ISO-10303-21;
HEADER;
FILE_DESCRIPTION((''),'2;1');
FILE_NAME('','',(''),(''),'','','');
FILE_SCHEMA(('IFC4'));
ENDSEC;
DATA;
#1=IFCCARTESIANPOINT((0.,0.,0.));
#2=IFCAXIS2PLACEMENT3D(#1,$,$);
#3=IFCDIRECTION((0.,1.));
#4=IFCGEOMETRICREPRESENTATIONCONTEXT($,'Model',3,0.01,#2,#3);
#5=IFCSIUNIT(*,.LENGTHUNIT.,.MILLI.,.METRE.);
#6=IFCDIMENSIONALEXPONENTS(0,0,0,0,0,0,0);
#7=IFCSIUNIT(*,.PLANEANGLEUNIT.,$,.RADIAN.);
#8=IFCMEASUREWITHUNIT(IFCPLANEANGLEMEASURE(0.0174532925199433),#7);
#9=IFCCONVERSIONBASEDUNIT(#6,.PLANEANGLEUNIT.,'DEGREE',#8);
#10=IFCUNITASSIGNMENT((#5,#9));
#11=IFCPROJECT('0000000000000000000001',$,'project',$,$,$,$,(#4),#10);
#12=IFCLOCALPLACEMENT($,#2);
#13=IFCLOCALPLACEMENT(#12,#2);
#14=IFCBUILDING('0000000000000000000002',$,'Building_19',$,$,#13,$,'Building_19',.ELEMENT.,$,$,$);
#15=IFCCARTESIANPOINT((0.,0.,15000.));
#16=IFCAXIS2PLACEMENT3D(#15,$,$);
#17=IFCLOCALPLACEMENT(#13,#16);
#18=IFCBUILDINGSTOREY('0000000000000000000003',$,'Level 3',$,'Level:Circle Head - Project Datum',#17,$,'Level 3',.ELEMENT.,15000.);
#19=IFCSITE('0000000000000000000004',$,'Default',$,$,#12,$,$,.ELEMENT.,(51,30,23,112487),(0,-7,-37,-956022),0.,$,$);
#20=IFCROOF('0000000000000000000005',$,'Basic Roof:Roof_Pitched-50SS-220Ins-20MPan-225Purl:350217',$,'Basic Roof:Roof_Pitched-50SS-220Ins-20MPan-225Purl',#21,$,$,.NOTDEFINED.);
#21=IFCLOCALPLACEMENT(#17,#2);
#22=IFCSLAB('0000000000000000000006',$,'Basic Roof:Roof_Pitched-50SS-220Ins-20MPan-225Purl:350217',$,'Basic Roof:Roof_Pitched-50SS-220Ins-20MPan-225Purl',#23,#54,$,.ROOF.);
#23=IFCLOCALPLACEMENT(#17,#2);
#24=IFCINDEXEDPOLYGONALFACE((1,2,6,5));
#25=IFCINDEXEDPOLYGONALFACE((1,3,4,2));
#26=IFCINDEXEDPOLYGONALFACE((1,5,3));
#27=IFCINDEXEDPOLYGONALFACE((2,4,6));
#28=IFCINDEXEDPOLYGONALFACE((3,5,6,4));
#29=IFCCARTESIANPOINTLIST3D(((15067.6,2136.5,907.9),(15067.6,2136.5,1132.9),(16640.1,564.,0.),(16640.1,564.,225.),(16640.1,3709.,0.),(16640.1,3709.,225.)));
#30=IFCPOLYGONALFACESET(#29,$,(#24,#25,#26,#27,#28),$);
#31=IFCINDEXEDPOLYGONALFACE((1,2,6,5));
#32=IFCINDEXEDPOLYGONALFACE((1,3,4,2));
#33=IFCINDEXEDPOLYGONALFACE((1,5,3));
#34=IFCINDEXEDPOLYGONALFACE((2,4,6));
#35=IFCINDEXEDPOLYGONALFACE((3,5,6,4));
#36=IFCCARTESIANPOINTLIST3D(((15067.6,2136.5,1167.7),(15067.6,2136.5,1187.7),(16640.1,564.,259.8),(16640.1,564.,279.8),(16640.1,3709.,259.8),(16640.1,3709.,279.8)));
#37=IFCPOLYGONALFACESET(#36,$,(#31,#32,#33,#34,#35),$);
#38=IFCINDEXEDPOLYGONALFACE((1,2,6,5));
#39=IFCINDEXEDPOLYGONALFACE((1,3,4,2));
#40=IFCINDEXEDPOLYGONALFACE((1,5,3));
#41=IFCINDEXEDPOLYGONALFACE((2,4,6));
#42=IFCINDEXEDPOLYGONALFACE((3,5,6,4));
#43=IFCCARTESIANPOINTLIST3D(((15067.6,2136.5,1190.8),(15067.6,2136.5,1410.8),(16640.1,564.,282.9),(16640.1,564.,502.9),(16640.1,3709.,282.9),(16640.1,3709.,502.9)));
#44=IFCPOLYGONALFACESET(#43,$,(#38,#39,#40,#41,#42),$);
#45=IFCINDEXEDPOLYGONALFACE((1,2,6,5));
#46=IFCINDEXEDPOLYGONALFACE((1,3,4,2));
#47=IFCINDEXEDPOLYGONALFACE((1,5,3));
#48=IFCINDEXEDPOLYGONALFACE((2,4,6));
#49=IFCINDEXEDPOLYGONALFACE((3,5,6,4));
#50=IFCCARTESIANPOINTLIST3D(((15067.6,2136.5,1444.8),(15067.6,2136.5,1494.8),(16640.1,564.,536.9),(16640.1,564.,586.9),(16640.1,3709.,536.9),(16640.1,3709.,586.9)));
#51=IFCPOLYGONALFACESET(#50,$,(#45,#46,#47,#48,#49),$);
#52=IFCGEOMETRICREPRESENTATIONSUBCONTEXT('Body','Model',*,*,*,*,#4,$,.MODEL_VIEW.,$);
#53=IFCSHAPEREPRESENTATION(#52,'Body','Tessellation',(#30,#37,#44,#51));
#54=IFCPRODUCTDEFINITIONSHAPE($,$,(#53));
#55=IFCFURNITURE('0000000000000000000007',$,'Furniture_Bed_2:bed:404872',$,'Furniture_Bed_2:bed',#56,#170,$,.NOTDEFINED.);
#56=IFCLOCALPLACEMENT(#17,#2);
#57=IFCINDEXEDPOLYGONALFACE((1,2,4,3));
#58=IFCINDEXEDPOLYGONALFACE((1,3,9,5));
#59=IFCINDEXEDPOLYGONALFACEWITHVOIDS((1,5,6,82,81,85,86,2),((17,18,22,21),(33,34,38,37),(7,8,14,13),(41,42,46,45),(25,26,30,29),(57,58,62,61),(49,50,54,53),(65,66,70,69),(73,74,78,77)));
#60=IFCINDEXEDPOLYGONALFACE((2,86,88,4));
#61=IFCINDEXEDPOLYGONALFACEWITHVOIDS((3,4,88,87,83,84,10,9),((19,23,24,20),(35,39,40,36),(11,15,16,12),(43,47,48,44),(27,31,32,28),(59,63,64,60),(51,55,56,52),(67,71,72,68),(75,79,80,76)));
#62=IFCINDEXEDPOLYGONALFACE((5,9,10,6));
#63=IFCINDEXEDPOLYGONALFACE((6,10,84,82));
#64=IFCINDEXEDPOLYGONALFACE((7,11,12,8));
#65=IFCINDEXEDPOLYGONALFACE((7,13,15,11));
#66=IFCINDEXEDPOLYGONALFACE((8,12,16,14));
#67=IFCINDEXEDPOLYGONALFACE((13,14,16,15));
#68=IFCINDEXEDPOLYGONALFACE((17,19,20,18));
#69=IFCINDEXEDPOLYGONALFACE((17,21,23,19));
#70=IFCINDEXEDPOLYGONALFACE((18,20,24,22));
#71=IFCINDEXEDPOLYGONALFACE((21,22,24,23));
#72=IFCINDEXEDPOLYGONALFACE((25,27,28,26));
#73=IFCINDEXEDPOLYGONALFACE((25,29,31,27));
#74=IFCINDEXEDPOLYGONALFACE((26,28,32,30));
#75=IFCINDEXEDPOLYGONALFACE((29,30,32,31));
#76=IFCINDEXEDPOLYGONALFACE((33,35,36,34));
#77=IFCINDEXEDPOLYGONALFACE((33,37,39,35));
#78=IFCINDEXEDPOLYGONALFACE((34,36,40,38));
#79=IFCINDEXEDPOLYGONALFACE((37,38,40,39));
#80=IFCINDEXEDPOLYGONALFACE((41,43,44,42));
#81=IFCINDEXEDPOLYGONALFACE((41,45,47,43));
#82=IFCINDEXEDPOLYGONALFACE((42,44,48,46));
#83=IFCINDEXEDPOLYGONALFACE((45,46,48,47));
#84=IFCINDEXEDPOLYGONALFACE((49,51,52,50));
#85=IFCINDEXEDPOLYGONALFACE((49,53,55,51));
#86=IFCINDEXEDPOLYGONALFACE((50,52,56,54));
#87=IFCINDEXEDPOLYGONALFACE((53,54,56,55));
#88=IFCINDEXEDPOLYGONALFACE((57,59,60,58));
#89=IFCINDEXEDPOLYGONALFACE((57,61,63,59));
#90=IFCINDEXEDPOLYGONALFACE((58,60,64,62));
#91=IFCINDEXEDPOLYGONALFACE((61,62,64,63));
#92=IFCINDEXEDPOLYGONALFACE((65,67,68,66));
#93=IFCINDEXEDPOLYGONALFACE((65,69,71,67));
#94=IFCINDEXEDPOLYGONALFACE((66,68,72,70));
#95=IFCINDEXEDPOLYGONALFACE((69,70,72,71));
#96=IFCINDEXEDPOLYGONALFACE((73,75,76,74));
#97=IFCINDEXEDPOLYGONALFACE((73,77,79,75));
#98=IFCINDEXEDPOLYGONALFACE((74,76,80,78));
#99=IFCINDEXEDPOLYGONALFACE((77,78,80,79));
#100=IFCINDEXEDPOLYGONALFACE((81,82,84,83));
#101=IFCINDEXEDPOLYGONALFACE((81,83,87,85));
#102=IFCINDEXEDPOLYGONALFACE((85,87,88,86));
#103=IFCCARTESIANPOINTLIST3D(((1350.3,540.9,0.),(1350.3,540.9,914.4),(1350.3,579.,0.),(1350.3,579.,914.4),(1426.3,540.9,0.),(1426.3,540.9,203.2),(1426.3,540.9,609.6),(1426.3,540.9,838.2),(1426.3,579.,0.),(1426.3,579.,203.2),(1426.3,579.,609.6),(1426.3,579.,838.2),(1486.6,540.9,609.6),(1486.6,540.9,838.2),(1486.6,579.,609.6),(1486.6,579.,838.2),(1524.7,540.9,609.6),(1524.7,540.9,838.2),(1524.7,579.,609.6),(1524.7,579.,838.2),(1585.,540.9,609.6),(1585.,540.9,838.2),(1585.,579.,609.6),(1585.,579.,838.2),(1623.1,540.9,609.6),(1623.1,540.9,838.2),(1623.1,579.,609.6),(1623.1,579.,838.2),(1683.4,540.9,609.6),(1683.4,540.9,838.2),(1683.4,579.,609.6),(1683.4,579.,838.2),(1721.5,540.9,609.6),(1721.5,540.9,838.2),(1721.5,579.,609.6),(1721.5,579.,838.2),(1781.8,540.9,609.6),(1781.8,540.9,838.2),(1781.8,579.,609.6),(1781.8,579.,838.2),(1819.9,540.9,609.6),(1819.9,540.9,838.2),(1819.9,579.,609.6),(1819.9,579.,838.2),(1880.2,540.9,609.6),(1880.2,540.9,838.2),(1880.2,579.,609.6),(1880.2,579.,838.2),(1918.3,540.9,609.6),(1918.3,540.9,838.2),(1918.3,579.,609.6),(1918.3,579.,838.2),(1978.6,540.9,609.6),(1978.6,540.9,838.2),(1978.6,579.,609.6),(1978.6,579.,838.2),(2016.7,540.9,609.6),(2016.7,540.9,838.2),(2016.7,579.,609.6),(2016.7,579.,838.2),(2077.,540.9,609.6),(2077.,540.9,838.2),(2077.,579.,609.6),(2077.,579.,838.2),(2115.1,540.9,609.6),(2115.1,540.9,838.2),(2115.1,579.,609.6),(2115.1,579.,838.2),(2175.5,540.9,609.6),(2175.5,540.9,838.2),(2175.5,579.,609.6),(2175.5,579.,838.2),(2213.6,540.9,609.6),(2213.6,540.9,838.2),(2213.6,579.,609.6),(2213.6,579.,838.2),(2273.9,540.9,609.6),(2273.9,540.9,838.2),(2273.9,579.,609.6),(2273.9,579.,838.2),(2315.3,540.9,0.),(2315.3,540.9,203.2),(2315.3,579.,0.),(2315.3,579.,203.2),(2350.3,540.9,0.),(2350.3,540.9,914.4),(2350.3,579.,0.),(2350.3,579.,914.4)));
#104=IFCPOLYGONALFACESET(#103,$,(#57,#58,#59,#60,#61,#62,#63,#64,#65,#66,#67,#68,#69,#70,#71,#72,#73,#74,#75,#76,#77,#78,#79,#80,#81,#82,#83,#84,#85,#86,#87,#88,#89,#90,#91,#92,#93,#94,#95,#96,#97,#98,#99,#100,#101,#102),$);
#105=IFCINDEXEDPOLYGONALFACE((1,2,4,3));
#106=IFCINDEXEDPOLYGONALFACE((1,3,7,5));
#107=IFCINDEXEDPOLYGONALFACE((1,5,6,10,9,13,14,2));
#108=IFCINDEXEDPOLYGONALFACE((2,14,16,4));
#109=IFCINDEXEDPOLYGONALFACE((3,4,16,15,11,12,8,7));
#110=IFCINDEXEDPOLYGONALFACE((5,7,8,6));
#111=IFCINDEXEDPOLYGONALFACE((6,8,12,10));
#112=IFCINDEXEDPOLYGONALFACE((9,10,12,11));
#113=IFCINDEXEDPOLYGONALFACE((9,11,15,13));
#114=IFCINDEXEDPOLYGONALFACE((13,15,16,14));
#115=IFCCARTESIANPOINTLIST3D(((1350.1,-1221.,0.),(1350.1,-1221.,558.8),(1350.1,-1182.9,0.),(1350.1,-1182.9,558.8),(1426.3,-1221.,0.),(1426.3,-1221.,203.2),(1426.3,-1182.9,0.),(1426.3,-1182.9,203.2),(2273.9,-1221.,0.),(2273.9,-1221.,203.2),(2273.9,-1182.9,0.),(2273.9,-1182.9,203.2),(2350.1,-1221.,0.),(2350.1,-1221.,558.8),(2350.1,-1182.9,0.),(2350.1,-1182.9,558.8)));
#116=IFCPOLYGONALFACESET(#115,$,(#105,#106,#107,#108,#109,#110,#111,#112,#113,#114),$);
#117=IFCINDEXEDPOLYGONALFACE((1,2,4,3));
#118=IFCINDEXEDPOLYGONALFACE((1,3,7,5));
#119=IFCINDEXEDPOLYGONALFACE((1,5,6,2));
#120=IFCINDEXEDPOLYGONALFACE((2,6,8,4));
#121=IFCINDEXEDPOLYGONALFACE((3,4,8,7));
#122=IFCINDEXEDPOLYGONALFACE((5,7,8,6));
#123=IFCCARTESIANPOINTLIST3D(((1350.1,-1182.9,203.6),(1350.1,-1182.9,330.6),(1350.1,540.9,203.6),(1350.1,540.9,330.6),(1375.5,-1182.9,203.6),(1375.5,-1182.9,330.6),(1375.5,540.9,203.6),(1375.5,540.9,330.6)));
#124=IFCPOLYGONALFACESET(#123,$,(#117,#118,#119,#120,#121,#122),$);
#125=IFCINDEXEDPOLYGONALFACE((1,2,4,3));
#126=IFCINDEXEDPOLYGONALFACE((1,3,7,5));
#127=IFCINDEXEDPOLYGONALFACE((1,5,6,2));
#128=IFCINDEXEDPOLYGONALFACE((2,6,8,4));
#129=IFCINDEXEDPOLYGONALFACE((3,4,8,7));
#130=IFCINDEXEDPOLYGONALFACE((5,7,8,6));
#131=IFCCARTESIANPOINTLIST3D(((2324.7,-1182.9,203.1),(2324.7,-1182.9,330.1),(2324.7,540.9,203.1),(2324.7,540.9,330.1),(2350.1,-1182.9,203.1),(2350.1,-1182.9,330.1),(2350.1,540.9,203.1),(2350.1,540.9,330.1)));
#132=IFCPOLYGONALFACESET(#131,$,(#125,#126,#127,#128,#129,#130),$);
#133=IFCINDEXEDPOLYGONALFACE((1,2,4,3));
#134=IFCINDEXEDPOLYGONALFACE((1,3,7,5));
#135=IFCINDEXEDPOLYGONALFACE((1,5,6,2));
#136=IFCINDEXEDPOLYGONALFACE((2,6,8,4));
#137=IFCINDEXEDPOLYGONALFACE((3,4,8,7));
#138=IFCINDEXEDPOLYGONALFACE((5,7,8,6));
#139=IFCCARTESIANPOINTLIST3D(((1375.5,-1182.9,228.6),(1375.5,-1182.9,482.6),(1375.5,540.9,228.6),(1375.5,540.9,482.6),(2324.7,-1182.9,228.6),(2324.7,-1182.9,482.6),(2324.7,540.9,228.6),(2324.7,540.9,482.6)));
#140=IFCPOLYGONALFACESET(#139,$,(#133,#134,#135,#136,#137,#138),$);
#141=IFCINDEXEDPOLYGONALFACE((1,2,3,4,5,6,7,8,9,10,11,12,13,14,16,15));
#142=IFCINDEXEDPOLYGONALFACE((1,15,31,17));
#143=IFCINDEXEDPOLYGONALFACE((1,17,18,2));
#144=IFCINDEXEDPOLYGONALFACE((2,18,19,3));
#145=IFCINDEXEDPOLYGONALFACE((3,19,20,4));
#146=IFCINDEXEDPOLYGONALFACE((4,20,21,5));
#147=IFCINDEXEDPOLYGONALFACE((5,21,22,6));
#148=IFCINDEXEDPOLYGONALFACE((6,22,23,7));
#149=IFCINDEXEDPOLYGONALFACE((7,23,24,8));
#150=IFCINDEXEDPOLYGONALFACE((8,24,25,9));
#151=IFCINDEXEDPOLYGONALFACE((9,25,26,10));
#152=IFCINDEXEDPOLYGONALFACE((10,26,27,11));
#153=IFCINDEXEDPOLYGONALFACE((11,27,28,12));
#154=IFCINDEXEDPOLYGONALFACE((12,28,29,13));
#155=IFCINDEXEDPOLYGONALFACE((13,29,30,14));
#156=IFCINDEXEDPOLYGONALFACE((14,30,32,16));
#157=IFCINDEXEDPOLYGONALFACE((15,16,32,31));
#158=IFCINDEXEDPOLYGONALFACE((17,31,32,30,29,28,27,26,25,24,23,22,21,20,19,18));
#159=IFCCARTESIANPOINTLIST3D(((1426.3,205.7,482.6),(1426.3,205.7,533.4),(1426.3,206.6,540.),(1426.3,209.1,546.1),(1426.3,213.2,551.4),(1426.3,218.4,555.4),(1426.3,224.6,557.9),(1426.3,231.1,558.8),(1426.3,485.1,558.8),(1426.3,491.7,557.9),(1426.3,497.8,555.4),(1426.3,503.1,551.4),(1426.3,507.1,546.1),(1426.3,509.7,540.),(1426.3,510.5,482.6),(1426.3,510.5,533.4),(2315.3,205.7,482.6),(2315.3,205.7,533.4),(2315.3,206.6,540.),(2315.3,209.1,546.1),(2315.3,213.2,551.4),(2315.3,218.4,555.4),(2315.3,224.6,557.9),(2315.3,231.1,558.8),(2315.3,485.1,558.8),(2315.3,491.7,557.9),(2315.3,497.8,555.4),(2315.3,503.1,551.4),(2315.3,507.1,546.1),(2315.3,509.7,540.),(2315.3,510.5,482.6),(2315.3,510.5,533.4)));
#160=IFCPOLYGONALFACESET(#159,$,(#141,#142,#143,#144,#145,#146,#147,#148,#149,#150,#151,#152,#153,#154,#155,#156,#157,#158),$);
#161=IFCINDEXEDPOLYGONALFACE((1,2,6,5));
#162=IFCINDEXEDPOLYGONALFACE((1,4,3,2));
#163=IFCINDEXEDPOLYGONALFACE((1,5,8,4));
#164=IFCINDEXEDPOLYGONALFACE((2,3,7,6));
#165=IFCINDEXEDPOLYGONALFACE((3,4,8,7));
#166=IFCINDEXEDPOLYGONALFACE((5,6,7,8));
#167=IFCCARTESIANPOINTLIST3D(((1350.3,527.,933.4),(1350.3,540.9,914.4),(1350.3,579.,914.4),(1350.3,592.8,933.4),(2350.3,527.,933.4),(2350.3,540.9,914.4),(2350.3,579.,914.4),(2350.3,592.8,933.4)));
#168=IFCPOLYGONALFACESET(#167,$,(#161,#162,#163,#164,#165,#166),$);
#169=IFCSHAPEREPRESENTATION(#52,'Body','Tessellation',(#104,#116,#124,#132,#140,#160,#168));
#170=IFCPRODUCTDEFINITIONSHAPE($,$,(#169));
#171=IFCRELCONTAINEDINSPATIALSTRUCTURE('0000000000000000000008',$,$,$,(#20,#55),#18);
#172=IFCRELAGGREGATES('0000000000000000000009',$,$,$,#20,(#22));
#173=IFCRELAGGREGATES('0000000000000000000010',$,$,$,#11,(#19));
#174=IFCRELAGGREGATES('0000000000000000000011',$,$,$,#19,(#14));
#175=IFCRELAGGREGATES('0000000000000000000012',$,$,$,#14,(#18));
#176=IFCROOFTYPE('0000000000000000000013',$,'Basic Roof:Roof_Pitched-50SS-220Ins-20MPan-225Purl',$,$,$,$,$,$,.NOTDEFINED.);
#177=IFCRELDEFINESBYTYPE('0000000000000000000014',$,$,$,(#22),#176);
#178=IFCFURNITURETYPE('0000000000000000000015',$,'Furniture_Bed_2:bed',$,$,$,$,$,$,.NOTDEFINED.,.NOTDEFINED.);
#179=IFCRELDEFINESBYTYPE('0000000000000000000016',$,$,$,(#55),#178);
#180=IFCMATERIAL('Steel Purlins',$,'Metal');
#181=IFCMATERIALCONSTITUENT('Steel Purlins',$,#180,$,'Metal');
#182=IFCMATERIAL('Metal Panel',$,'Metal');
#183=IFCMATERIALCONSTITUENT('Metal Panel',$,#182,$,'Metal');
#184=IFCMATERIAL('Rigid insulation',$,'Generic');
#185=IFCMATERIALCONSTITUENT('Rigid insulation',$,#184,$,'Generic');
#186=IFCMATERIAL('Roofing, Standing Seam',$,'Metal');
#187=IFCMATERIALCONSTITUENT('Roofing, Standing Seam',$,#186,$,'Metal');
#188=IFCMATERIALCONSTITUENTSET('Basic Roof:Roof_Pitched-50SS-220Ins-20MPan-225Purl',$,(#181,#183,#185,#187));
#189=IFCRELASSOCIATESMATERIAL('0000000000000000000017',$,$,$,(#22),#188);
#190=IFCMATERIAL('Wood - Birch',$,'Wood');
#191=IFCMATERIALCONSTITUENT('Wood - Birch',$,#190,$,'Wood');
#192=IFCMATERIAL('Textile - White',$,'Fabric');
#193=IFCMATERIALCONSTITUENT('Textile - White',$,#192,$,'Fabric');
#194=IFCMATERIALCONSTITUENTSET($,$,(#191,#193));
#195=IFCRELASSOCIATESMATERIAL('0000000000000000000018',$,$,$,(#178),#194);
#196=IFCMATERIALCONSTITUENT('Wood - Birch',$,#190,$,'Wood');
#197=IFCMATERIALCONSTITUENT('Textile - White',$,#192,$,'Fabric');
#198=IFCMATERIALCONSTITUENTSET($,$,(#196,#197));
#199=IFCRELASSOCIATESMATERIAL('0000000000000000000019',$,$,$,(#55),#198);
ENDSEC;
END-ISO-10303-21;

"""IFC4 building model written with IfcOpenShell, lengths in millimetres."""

from ifc_helpers import new_model, entity, si_unit, converted_unit, direction, frame, origin, place, context, subcontext, project, spatial, line, arc, indexed_curve, outline, extrude, source, transform, mapped, material, constituent, constituent_set, type_object, type_shapes, element, aggregate, save


model = new_model("IFC4")

# Units and contexts
model_context = context("Model", 3, precision=0.01, world=origin(), true_north=direction((0.0, 1.0)))
body_context = subcontext(model_context, "Body", "Model", "MODEL_VIEW")
ifc_project = project(units=[si_unit("LENGTHUNIT", "METRE", prefix="MILLI"), converted_unit("PLANEANGLEUNIT", "DEGREE", entity("IfcPlaneAngleMeasure", 0.0174532925199433), si_unit("PLANEANGLEUNIT", "RADIAN"), dimensions=[0, 0, 0, 0, 0, 0, 0])], contexts=[model_context])

# Site, building, storey
site_placement = place(None, origin())
site = spatial("IfcSite", under=ifc_project, at=site_placement, Name="Default", CompositionType="ELEMENT", RefLatitude=(51, 30, 23, 112487), RefLongitude=(0, -7, -37, -956022), RefElevation=0.0)
building_placement = place(site_placement, origin())
building = spatial("IfcBuilding", under=site, at=building_placement, Name="Building_19", LongName="Building_19", CompositionType="ELEMENT")
storey_placement = place(building_placement, frame((0.0, 0.0, 15000.0)))
storey = spatial("IfcBuildingStorey", under=building, at=storey_placement, Name="Level 3", ObjectType="Level:Circle Head - Project Datum", LongName="Level 3", CompositionType="ELEMENT", Elevation=15000.0)

# Shared definitions
ifc_material_1 = material(Name="Rigid insulation", Category="Generic")

# Roof, slab
ifc_material_2 = material(Name="Steel Purlins", Category="Metal")
ifc_constituent_1 = constituent(ifc_material_2, Name="Steel Purlins", Category="Metal")
ifc_material_3 = material(Name="Metal Panel", Category="Metal")
ifc_constituent_2 = constituent(ifc_material_3, Name="Metal Panel", Category="Metal")
ifc_constituent_3 = constituent(ifc_material_1, Name="Rigid insulation", Category="Generic")
ifc_material_4 = material(Name="Roofing, Standing Seam", Category="Metal")
ifc_constituent_4 = constituent(ifc_material_4, Name="Roofing, Standing Seam", Category="Metal")
ifc_constituent_set_1 = constituent_set(constituents=[ifc_constituent_1, ifc_constituent_2, ifc_constituent_3, ifc_constituent_4], Name="Basic Roof:Roof_Pitched-50SS-220Ins-20MPan-225Purl")
roof_type = type_object("IfcRoofType", Name="Basic Roof:Roof_Pitched-50SS-220Ins-20MPan-225Purl", PredefinedType="NOTDEFINED")
roof_1_placement = place(storey_placement, frame((2640.1, 564.0, 0.0)))
roof_1 = element("IfcRoof", 1, at=roof_1_placement, inside=storey, Name="Basic Roof:Roof_Pitched-50SS-220Ins-20MPan-225Purl:350217", ObjectType="Basic Roof:Roof_Pitched-50SS-220Ins-20MPan-225Purl", PredefinedType="NOTDEFINED")
slab_1_placement = place(roof_1_placement, origin())
slab_1 = element("IfcSlab", 2, at=slab_1_placement, type_object=roof_type, material=ifc_constituent_set_1, Name="Basic Roof:Roof_Pitched-50SS-220Ins-20MPan-225Purl:350217", ObjectType="Basic Roof:Roof_Pitched-50SS-220Ins-20MPan-225Purl", PredefinedType="ROOF", context=body_context, shape_type="SweptSolid", body=[
    extrude(outline(indexed_curve([(-907.9, 0.0), (907.9, -1572.5), (907.9, 1572.5), (-907.9, 0.0)], self_intersect=False)), frame((13213.8, 1572.5, 453.9), z_axis=(0.5, 0.0, 0.866025), x_axis=(0.866025, 0.0, -0.5)), (-0.5, 0.0, 0.866025), 225.0),
    extrude(outline(indexed_curve([(-907.9, 0.0), (907.9, -1572.5), (907.9, 1572.5), (-907.9, 0.0)], self_intersect=False)), frame((13213.8, 1572.5, 713.7), z_axis=(0.5, 0.0, 0.866025), x_axis=(0.866025, 0.0, -0.5)), (-0.5, 0.0, 0.866025), 20.0),
    extrude(outline(indexed_curve([(-907.9, 0.0), (907.9, -1572.5), (907.9, 1572.5), (-907.9, 0.0)], self_intersect=False)), frame((13213.8, 1572.5, 736.8), z_axis=(0.5, 0.0, 0.866025), x_axis=(0.866025, 0.0, -0.5)), (-0.5, 0.0, 0.866025), 220.0),
    extrude(outline(indexed_curve([(-907.9, 0.0), (907.9, -1572.5), (907.9, 1572.5), (-907.9, 0.0)], self_intersect=False)), frame((13213.8, 1572.5, 990.9), z_axis=(0.5, 0.0, 0.866025), x_axis=(0.866025, 0.0, -0.5)), (-0.5, 0.0, 0.866025), 50.0),
])
aggregate(roof_1, [slab_1])

# Furniture
ifc_material_5 = material(Name="Wood - Birch", Category="Wood")
ifc_constituent_5 = constituent(ifc_material_5, Name="Wood - Birch", Category="Wood")
ifc_material_6 = material(Name="Textile - White", Category="Fabric")
ifc_constituent_6 = constituent(ifc_material_6, Name="Textile - White", Category="Fabric")
ifc_constituent_set_2 = constituent_set(constituents=[ifc_constituent_5, ifc_constituent_6])
ifc_constituent_7 = constituent(ifc_material_5, Name="Wood - Birch", Category="Wood")
ifc_constituent_8 = constituent(ifc_material_6, Name="Textile - White", Category="Fabric")
ifc_constituent_set_3 = constituent_set(constituents=[ifc_constituent_7, ifc_constituent_8])
furniture_type_1 = type_object("IfcFurnitureType", Name="Furniture_Bed_2:bed", AssemblyPlace="NOTDEFINED", PredefinedType="NOTDEFINED", material=ifc_constituent_set_3)
shared_shape_1 = source(origin(), body_context, "Body", "SweptSolid", [
    extrude(outline(indexed_curve([(-635.0, -489.8), (279.4, -489.8), (279.4, -454.7), (76.2, -454.7), (76.2, 434.3), (279.4, 434.3), (279.4, 510.3), (-635.0, 510.3), (-635.0, -489.8)], self_intersect=False), holes=[indexed_curve([(-558.8, 374.0), (-558.8, 434.3), (-330.2, 434.3), (-330.2, 374.0), (-558.8, 374.0)], self_intersect=False), indexed_curve([(-558.8, 275.5), (-558.8, 335.9), (-330.2, 335.9), (-330.2, 275.5), (-558.8, 275.5)], self_intersect=False), indexed_curve([(-558.8, 177.1), (-558.8, 237.4), (-330.2, 237.4), (-330.2, 177.1), (-558.8, 177.1)], self_intersect=False), indexed_curve([(-558.8, 78.7), (-558.8, 139.0), (-330.2, 139.0), (-330.2, 78.7), (-558.8, 78.7)], self_intersect=False), indexed_curve([(-558.8, -118.1), (-558.8, -57.8), (-330.2, -57.8), (-330.2, -118.1), (-558.8, -118.1)], self_intersect=False), indexed_curve([(-558.8, -216.5), (-558.8, -156.2), (-330.2, -156.2), (-330.2, -216.5), (-558.8, -216.5)], self_intersect=False), indexed_curve([(-558.8, -314.9), (-558.8, -254.6), (-330.2, -254.6), (-330.2, -314.9), (-558.8, -314.9)], self_intersect=False), indexed_curve([(-558.8, -413.3), (-558.8, -353.0), (-330.2, -353.0), (-330.2, -413.3), (-558.8, -413.3)], self_intersect=False), indexed_curve([(-558.8, -19.7), (-558.8, 40.6), (-330.2, 40.6), (-330.2, -19.7), (-558.8, -19.7)], self_intersect=False)]), frame((-8.6, -38.1, 279.4), z_axis=(0.0, 1.0, 0.0), x_axis=(0.0, 0.0, -1.0)), (0.0, 0.0, 1.0), 38.1),
    extrude(outline(indexed_curve([(423.8, -190.5), (500.0, -190.5), (500.0, 368.3), (-500.0, 368.3), (-500.0, -190.5), (-423.8, -190.5), (-423.8, 12.7), (423.8, 12.7), (423.8, -190.5)], self_intersect=False)), frame((-19.1, -1800.0, 190.5), z_axis=(0.0, 1.0, 0.0), x_axis=(-1.0, 0.0, 0.0)), (0.0, 0.0, 1.0), 38.1),
    extrude(outline(indexed_curve([(-12.7, -861.9), (12.7, -861.9), (12.7, 861.9), (-12.7, 861.9), (-12.7, -861.9)], self_intersect=False)), frame((-506.4, -900.0, 203.6)), (0.0, 0.0, 1.0), 127.0),
    extrude(outline(indexed_curve([(-12.7, -861.9), (12.7, -861.9), (12.7, 861.9), (-12.7, 861.9), (-12.7, -861.9)], self_intersect=False)), frame((468.2, -900.0, 203.1)), (0.0, 0.0, 1.0), 127.0),
    extrude(outline(indexed_curve([(-474.6, -861.9), (474.6, -861.9), (474.6, 861.9), (-474.6, 861.9), (-474.6, -861.9)], self_intersect=False)), frame((-19.0, -900.0, 228.6), z_axis=(0.0, 0.0, 1.0), x_axis=(-1.0, 0.0, 0.0)), (0.0, 0.0, 1.0), 254.0),
    extrude(outline(indexed_curve([(-152.4, -42.3), (152.4, -42.3), (152.4, 8.5), (145.0, 26.4), (127.0, 33.9), (-127.0, 33.9), (-145.0, 26.4), (-152.4, 8.5)], segments=[line(1, 2, 3), arc(3, 4, 5), line(5, 6), arc(6, 7, 8), line(8, 1)], self_intersect=False)), frame((-442.9, -220.8, 524.9), z_axis=(1.0, 0.0, 0.0), x_axis=(0.0, 1.0, 0.0)), (0.0, 0.0, 1.0), 889.0),
    extrude(outline(indexed_curve([(-19.1, -9.5), (19.0, -9.5), (32.9, 9.5), (-32.9, 9.5), (-19.1, -9.5)], self_intersect=False)), frame((-518.8, -19.0, 923.9), z_axis=(1.0, 0.0, 0.0), x_axis=(0.0, 1.0, 0.0)), (0.0, 0.0, 1.0), 1000.1),
])
type_shapes(furniture_type_1, [shared_shape_1])
furniture_1_placement = place(storey_placement, frame((1869.1, 579.0, 0.0)))
element("IfcFurniture", 3, at=furniture_1_placement, inside=storey, type_object=furniture_type_1, material=ifc_constituent_set_2, Name="Furniture_Bed_2:bed:404872", ObjectType="Furniture_Bed_2:bed", PredefinedType="NOTDEFINED", context=body_context, shape_type="MappedRepresentation", body=[
    mapped(shared_shape_1, transform((0.0, 0.0, 0.0), scale=1.0)),
])

save(model, "model.ifc")
